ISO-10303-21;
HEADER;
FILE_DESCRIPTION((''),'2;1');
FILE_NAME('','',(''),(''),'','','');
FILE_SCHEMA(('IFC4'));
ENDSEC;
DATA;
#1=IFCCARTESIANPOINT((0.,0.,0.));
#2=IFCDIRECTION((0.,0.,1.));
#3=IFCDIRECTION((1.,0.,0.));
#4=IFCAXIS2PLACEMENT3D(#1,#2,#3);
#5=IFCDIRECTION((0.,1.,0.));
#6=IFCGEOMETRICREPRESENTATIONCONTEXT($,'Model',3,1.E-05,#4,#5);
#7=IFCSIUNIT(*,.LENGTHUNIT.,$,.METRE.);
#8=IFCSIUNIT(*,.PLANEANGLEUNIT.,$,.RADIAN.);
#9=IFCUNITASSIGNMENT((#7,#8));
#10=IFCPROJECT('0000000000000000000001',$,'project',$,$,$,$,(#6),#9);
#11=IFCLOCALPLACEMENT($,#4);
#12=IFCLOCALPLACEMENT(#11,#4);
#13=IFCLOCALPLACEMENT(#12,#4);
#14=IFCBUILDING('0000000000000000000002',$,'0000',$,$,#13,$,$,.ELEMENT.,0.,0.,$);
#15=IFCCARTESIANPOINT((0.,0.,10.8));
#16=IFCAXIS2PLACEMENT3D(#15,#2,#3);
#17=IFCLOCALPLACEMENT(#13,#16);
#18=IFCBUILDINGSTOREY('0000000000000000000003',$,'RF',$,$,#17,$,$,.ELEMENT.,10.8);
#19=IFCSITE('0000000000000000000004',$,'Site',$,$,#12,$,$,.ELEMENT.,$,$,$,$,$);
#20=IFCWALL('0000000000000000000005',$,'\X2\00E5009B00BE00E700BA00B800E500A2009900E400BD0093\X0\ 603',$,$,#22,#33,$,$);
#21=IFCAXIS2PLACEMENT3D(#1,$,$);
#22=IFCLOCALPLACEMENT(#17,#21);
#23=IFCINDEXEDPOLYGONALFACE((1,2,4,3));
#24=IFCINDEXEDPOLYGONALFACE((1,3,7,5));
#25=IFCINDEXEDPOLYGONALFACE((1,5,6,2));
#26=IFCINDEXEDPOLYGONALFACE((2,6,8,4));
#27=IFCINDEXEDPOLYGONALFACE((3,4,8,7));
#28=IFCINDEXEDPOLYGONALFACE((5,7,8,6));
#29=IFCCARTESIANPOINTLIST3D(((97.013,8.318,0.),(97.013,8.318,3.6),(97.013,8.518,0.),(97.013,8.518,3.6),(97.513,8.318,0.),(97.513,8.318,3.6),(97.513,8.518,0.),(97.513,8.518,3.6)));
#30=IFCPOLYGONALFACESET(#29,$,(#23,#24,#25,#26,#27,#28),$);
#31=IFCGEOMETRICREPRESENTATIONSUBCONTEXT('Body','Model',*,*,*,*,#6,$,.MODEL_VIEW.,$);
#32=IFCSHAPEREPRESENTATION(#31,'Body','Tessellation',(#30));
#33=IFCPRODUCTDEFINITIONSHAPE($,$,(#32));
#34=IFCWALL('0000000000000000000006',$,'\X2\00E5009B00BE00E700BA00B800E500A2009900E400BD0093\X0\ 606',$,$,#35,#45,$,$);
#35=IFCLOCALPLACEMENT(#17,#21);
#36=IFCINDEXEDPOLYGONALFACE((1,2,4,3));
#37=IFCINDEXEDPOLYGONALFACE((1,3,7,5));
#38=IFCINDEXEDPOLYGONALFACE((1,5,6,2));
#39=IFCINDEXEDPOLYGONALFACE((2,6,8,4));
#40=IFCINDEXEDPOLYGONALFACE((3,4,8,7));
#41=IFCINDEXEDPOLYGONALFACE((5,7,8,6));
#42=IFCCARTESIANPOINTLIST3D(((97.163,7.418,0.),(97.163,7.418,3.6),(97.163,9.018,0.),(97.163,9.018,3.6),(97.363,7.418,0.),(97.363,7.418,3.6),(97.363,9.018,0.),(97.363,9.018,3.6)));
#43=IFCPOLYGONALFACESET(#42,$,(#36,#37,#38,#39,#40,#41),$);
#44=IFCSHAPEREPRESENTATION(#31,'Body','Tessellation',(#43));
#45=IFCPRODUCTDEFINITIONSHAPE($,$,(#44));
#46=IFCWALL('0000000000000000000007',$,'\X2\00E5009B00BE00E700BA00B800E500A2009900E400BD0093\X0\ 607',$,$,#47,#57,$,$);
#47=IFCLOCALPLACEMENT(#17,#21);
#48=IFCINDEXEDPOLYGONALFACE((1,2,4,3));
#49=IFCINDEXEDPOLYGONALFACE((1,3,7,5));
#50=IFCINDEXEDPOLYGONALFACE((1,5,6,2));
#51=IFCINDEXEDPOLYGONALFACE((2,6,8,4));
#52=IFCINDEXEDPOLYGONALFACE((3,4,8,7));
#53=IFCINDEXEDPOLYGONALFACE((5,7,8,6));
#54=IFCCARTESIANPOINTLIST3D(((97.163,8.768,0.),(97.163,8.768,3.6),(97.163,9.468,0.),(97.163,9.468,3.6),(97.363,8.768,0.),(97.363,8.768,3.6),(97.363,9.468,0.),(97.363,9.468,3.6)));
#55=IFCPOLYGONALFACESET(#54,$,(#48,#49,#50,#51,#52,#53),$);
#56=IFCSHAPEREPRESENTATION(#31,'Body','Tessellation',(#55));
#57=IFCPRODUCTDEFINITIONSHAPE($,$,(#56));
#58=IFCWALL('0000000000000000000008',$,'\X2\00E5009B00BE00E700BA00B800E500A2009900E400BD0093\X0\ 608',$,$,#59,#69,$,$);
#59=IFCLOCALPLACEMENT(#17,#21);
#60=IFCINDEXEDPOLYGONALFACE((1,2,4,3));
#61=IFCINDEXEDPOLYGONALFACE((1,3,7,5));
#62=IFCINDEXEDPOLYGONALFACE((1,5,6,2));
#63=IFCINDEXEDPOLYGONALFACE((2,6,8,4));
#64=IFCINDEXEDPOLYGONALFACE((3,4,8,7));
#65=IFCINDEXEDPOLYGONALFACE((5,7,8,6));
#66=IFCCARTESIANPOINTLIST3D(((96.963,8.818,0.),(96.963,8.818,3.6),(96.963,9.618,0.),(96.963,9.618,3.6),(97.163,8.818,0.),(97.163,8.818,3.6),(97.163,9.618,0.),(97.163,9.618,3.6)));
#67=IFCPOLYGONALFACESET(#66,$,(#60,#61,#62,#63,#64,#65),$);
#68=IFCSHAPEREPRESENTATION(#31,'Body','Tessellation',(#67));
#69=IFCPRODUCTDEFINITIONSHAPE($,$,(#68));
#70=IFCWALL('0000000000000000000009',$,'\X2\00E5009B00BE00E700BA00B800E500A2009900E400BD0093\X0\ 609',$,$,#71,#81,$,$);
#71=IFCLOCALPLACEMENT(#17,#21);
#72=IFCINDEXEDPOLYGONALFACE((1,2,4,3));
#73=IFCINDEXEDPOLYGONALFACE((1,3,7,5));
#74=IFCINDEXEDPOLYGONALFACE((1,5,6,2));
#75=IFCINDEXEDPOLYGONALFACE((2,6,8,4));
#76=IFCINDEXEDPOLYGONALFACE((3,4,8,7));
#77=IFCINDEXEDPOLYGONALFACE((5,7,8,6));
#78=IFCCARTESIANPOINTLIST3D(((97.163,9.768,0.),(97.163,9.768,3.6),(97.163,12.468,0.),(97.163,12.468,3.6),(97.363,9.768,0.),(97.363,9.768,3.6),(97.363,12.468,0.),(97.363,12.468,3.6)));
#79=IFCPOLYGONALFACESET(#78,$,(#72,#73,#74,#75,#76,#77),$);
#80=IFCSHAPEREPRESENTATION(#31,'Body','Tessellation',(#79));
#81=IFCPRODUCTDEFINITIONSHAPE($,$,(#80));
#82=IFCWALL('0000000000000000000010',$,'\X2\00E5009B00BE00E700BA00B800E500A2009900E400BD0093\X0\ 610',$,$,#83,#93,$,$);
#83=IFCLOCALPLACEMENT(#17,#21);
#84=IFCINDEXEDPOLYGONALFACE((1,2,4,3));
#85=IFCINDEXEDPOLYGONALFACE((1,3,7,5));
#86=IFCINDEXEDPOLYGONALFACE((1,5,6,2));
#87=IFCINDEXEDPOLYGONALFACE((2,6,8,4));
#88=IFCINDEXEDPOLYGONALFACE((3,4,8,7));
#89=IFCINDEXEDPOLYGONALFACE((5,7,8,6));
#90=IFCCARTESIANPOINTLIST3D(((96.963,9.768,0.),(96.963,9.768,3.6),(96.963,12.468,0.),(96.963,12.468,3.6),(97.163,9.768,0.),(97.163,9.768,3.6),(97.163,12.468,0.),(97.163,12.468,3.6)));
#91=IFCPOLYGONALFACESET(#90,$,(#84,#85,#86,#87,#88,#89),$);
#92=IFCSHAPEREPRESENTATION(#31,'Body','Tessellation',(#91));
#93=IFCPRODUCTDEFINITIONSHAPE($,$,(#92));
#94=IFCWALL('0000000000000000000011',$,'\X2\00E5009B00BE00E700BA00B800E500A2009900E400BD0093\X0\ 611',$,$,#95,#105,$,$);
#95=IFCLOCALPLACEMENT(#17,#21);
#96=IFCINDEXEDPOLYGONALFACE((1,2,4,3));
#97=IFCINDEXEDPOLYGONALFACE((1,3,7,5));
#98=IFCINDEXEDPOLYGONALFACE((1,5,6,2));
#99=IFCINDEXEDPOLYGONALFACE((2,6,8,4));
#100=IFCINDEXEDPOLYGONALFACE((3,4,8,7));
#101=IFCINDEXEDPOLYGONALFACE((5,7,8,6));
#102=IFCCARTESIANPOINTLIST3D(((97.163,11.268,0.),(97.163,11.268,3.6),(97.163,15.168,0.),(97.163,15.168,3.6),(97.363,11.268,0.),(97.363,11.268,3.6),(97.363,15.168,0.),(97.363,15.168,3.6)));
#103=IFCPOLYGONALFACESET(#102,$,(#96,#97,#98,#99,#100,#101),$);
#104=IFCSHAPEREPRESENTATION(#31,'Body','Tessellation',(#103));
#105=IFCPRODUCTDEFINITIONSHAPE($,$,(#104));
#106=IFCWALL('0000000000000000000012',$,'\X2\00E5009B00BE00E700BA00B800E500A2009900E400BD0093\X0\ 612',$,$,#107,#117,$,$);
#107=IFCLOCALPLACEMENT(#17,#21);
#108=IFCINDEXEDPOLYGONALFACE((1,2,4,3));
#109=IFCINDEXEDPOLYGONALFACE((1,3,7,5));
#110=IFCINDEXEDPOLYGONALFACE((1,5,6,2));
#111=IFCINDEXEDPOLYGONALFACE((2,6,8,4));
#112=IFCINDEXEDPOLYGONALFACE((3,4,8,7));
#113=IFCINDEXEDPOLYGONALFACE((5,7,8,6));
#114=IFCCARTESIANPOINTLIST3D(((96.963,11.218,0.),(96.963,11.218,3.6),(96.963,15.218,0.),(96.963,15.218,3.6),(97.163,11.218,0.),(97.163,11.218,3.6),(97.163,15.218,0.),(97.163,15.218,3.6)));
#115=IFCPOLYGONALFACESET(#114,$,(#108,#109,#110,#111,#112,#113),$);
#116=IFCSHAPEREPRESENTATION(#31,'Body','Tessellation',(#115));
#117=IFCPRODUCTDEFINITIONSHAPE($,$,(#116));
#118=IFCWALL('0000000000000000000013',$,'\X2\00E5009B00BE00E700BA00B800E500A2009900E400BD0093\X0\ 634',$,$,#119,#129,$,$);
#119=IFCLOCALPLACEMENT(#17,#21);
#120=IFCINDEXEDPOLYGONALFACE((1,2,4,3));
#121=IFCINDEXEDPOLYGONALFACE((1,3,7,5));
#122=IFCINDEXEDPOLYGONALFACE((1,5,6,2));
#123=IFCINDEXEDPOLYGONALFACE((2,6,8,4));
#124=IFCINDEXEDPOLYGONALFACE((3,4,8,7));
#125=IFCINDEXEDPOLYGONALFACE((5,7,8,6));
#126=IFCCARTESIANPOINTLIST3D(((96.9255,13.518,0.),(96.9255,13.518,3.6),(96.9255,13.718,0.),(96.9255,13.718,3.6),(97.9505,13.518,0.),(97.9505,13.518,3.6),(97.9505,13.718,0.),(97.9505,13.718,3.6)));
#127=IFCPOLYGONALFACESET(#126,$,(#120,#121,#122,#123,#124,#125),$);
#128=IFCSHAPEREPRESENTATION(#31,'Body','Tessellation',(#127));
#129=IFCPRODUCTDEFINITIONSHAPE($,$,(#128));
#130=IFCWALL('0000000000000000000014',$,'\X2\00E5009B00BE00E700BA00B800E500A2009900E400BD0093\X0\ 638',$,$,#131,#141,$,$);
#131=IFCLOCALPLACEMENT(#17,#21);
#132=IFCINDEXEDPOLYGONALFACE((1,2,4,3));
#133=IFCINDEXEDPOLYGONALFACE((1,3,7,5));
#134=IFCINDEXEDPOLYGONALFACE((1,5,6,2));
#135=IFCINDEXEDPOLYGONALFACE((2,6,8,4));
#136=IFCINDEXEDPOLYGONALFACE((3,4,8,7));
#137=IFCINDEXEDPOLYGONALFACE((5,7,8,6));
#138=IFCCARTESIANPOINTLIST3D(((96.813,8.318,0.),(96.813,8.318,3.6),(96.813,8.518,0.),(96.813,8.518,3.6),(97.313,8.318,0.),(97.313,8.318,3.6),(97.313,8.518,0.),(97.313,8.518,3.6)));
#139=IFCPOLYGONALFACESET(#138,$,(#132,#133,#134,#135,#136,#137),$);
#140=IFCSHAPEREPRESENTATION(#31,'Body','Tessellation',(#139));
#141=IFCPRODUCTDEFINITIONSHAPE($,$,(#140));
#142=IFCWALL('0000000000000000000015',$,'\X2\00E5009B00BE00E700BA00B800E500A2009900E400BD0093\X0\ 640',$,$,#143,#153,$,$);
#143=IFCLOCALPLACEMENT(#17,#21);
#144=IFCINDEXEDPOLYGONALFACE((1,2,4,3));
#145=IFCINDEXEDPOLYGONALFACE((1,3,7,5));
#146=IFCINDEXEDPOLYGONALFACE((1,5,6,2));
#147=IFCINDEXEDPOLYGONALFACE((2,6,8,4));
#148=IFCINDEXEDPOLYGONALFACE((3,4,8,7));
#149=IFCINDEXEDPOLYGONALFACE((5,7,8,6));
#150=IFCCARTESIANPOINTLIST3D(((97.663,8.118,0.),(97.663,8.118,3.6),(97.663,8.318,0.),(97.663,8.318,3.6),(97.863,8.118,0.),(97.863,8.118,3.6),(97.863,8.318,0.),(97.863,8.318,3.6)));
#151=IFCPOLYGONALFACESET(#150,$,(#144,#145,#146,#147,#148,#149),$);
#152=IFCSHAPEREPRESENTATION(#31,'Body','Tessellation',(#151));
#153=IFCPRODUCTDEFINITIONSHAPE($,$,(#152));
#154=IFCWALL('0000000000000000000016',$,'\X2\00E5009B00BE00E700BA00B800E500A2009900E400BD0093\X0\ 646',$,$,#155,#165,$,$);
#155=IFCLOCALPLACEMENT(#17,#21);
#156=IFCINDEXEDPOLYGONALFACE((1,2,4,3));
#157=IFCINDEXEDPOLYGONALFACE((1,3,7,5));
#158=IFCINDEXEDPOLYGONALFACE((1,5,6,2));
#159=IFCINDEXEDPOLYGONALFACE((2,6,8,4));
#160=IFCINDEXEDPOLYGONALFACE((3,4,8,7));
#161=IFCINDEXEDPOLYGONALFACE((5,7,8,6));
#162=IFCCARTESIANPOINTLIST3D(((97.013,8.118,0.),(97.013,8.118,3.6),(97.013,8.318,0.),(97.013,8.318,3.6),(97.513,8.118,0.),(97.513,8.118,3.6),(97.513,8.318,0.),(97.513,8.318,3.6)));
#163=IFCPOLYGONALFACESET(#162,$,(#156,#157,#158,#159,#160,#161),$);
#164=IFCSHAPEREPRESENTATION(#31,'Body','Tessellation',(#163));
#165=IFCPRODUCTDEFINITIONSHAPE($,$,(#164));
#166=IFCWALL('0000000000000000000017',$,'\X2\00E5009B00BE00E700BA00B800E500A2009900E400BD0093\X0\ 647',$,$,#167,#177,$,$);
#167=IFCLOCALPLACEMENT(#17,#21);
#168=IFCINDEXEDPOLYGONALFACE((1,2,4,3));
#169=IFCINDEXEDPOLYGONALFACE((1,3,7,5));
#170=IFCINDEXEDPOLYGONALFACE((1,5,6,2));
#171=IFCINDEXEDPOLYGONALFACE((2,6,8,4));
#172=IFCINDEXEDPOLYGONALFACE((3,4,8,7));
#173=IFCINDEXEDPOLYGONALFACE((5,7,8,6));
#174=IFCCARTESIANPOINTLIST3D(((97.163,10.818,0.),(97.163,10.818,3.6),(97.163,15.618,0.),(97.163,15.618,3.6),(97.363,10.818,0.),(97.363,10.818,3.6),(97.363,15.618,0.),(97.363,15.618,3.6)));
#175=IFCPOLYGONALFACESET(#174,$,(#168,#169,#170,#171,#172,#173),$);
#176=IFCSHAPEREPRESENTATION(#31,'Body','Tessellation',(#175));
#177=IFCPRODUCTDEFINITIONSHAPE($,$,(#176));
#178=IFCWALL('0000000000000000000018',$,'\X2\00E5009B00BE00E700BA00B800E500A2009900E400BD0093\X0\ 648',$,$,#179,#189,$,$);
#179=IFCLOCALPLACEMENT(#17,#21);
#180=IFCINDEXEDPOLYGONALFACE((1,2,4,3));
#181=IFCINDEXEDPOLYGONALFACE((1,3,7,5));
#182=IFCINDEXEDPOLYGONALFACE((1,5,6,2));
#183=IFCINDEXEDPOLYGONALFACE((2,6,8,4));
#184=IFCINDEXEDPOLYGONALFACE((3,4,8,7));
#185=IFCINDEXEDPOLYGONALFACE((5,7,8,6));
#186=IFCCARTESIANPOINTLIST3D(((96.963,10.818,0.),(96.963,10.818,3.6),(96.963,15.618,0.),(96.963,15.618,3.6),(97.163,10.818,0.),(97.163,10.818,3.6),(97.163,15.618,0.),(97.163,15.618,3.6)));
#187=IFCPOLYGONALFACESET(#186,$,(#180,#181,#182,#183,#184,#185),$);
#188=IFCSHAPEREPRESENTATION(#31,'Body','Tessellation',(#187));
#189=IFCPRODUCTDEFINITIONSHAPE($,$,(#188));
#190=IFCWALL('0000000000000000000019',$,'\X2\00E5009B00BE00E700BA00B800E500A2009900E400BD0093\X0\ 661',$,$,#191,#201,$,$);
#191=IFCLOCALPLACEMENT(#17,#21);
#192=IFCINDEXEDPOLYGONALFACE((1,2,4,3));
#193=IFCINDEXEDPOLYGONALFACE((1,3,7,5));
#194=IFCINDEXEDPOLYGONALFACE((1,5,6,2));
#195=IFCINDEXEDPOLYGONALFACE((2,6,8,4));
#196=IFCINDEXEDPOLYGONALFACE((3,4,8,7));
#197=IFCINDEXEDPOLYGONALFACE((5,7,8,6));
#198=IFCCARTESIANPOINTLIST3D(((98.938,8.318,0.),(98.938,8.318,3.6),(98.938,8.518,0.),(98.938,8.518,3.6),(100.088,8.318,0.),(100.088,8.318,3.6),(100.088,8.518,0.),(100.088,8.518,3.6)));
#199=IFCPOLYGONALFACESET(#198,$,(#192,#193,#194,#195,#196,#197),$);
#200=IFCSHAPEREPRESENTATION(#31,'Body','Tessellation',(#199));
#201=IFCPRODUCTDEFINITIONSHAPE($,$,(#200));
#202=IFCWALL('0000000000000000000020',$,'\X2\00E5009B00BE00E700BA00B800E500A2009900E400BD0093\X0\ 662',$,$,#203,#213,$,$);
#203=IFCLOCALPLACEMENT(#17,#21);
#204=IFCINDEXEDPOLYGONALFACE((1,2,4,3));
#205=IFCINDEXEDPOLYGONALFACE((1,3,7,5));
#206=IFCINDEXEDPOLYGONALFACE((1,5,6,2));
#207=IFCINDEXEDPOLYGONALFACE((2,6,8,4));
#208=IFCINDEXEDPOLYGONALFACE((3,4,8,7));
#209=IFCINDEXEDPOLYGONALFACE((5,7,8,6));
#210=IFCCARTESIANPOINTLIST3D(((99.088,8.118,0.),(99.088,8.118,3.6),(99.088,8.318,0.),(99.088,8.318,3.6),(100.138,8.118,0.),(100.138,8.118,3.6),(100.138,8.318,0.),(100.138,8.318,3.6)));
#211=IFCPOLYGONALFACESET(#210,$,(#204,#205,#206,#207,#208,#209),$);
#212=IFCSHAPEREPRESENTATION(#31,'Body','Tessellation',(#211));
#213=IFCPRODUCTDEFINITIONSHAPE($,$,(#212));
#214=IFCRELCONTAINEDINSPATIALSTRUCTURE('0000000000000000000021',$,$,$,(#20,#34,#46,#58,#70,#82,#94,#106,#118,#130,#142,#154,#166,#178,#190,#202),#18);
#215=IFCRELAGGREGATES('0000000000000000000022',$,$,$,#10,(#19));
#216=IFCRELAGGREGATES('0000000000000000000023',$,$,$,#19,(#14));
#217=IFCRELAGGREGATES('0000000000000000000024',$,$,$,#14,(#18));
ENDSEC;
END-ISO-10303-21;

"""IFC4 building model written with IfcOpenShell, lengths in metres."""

from ifc_helpers import new_model, si_unit, direction, frame, frame_2d, origin_with_axes, place, context, subcontext, project, spatial, rectangle, extrude, element, save


model = new_model("IFC4")

# Units and contexts
model_context = context("Model", 3, precision=1e-05, world=origin_with_axes(), true_north=direction((0.0, 1.0, 0.0)))
body_context = subcontext(model_context, "Body", "Model", "MODEL_VIEW")
ifc_project = project(units=[si_unit("LENGTHUNIT", "METRE"), si_unit("PLANEANGLEUNIT", "RADIAN")], contexts=[model_context])

# Site, building, storey
placement = place(None, origin_with_axes())
site_placement = place(placement, origin_with_axes())
site = spatial("IfcSite", under=ifc_project, at=site_placement, Name="Site", CompositionType="ELEMENT")
building_placement = place(site_placement, origin_with_axes())
building = spatial("IfcBuilding", under=site, at=building_placement, Name="0000", CompositionType="ELEMENT", ElevationOfRefHeight=0.0, ElevationOfTerrain=0.0)
storey_placement = place(building_placement, frame((0.0, 0.0, 10.8), z_axis=(0.0, 0.0, 1.0), x_axis=(1.0, 0.0, 0.0)))
storey = spatial("IfcBuildingStorey", under=building, at=storey_placement, Name="RF", CompositionType="ELEMENT", Elevation=10.8)

# Walls
wall_1_placement = place(storey_placement, frame((97.263, 8.418, 0.0), z_axis=(0.0, 0.0, 1.0), x_axis=(1.0, 0.0, 0.0)))
element("IfcWall", 1, at=wall_1_placement, inside=storey, Name="å\u009b¾çº¸å¢\u0099ä½\u0093 603", context=body_context, shape_type="SweptSolid", body=[
    extrude(rectangle(XDim=0.5, YDim=0.2, at=frame_2d((0.0, 0.0), x_axis=(1.0, 0.0, 0.0))), frame((0.0, 0.0, 0.0), z_axis=(0.0, 0.0, 1.0)), (0.0, 0.0, 1.0), 3.6),
])
wall_2_placement = place(storey_placement, frame((97.263, 8.218, 0.0), z_axis=(0.0, 0.0, 1.0), x_axis=(0.0, -1.0, 0.0)))
element("IfcWall", 2, at=wall_2_placement, inside=storey, Name="å\u009b¾çº¸å¢\u0099ä½\u0093 606", context=body_context, shape_type="SweptSolid", body=[
    extrude(rectangle(XDim=1.6, YDim=0.2, at=frame_2d((0.0, 0.0), x_axis=(1.0, 0.0, 0.0))), frame((0.0, 0.0, 0.0), z_axis=(0.0, 0.0, 1.0)), (0.0, 0.0, 1.0), 3.6),
])
wall_3_placement = place(storey_placement, frame((97.263, 9.118, 0.0), z_axis=(0.0, 0.0, 1.0), x_axis=(0.0, -1.0, 0.0)))
element("IfcWall", 3, at=wall_3_placement, inside=storey, Name="å\u009b¾çº¸å¢\u0099ä½\u0093 607", context=body_context, shape_type="SweptSolid", body=[
    extrude(rectangle(XDim=0.7, YDim=0.2, at=frame_2d((0.0, 0.0), x_axis=(1.0, 0.0, 0.0))), frame((0.0, 0.0, 0.0), z_axis=(0.0, 0.0, 1.0)), (0.0, 0.0, 1.0), 3.6),
])
wall_4_placement = place(storey_placement, frame((97.063, 9.218, 0.0), z_axis=(0.0, 0.0, 1.0), x_axis=(0.0, -1.0, 0.0)))
element("IfcWall", 4, at=wall_4_placement, inside=storey, Name="å\u009b¾çº¸å¢\u0099ä½\u0093 608", context=body_context, shape_type="SweptSolid", body=[
    extrude(rectangle(XDim=0.8, YDim=0.2, at=frame_2d((0.0, 0.0), x_axis=(1.0, 0.0, 0.0))), frame((0.0, 0.0, 0.0), z_axis=(0.0, 0.0, 1.0)), (0.0, 0.0, 1.0), 3.6),
])
for number, where, z_axis, x_axis, name in (
    (5, (97.263, 11.118, 0.0), (0.0, 0.0, 1.0), (0.0, -1.0, 0.0), "å\u009b¾çº¸å¢\u0099ä½\u0093 609"),
    (6, (97.063, 11.118, 0.0), (0.0, 0.0, 1.0), (0.0, -1.0, 0.0), "å\u009b¾çº¸å¢\u0099ä½\u0093 610"),
):
    element("IfcWall", number, at=place(storey_placement, frame(where, z_axis=z_axis, x_axis=x_axis)), inside=storey, Name=name, context=body_context, shape_type="SweptSolid", body=[
        extrude(rectangle(XDim=2.7, YDim=0.2, at=frame_2d((0.0, 0.0), x_axis=(1.0, 0.0, 0.0))), frame((0.0, 0.0, 0.0), z_axis=(0.0, 0.0, 1.0)), (0.0, 0.0, 1.0), 3.6),
    ])
wall_5_placement = place(storey_placement, frame((97.263, 13.218, 0.0), z_axis=(0.0, 0.0, 1.0), x_axis=(0.0, -1.0, 0.0)))
element("IfcWall", 7, at=wall_5_placement, inside=storey, Name="å\u009b¾çº¸å¢\u0099ä½\u0093 611", context=body_context, shape_type="SweptSolid", body=[
    extrude(rectangle(XDim=3.9, YDim=0.2, at=frame_2d((0.0, 0.0), x_axis=(1.0, 0.0, 0.0))), frame((0.0, 0.0, 0.0), z_axis=(0.0, 0.0, 1.0)), (0.0, 0.0, 1.0), 3.6),
])
wall_6_placement = place(storey_placement, frame((97.063, 13.218, 0.0), z_axis=(0.0, 0.0, 1.0), x_axis=(0.0, -1.0, 0.0)))
element("IfcWall", 8, at=wall_6_placement, inside=storey, Name="å\u009b¾çº¸å¢\u0099ä½\u0093 612", context=body_context, shape_type="SweptSolid", body=[
    extrude(rectangle(XDim=4.0, YDim=0.2, at=frame_2d((0.0, 0.0), x_axis=(1.0, 0.0, 0.0))), frame((0.0, 0.0, 0.0), z_axis=(0.0, 0.0, 1.0)), (0.0, 0.0, 1.0), 3.6),
])
wall_7_placement = place(storey_placement, frame((97.438, 13.618, 0.0), z_axis=(0.0, 0.0, 1.0), x_axis=(1.0, 0.0, 0.0)))
element("IfcWall", 9, at=wall_7_placement, inside=storey, Name="å\u009b¾çº¸å¢\u0099ä½\u0093 634", context=body_context, shape_type="SweptSolid", body=[
    extrude(rectangle(XDim=1.025, YDim=0.2, at=frame_2d((0.0, 0.0), x_axis=(1.0, 0.0, 0.0))), frame((0.0, 0.0, 0.0), z_axis=(0.0, 0.0, 1.0)), (0.0, 0.0, 1.0), 3.6),
])
wall_8_placement = place(storey_placement, frame((97.063, 8.418, 0.0), z_axis=(0.0, 0.0, 1.0), x_axis=(-1.0, 0.0, 0.0)))
element("IfcWall", 10, at=wall_8_placement, inside=storey, Name="å\u009b¾çº¸å¢\u0099ä½\u0093 638", context=body_context, shape_type="SweptSolid", body=[
    extrude(rectangle(XDim=0.5, YDim=0.2, at=frame_2d((0.0, 0.0), x_axis=(1.0, 0.0, 0.0))), frame((0.0, 0.0, 0.0), z_axis=(0.0, 0.0, 1.0)), (0.0, 0.0, 1.0), 3.6),
])
wall_9_placement = place(storey_placement, frame((97.763, 8.218, 0.0), z_axis=(0.0, 0.0, 1.0), x_axis=(0.0, 1.0, 0.0)))
element("IfcWall", 11, at=wall_9_placement, inside=storey, Name="å\u009b¾çº¸å¢\u0099ä½\u0093 640", context=body_context, shape_type="SweptSolid", body=[
    extrude(rectangle(XDim=0.2, YDim=0.2, at=frame_2d((0.0, 0.0), x_axis=(1.0, 0.0, 0.0))), frame((0.0, 0.0, 0.0), z_axis=(0.0, 0.0, 1.0)), (0.0, 0.0, 1.0), 3.6),
])
for number, where, z_axis, x_axis, name in (
    (12, (97.263, 8.218, 0.0), (0.0, 0.0, 1.0), (1.0, 0.0, 0.0), "å\u009b¾çº¸å¢\u0099ä½\u0093 646"),
):
    element("IfcWall", number, at=place(storey_placement, frame(where, z_axis=z_axis, x_axis=x_axis)), inside=storey, Name=name, context=body_context, shape_type="SweptSolid", body=[
        extrude(rectangle(XDim=0.5, YDim=0.2, at=frame_2d((0.0, 0.0), x_axis=(1.0, 0.0, 0.0))), frame((0.0, 0.0, 0.0), z_axis=(0.0, 0.0, 1.0)), (0.0, 0.0, 1.0), 3.6),
    ])
for number, where, z_axis, x_axis, name in (
    (13, (97.263, 13.218, 0.0), (0.0, 0.0, 1.0), (0.0, -1.0, 0.0), "å\u009b¾çº¸å¢\u0099ä½\u0093 647"),
    (14, (97.063, 13.218, 0.0), (0.0, 0.0, 1.0), (0.0, -1.0, 0.0), "å\u009b¾çº¸å¢\u0099ä½\u0093 648"),
):
    element("IfcWall", number, at=place(storey_placement, frame(where, z_axis=z_axis, x_axis=x_axis)), inside=storey, Name=name, context=body_context, shape_type="SweptSolid", body=[
        extrude(rectangle(XDim=4.8, YDim=0.2, at=frame_2d((0.0, 0.0), x_axis=(1.0, 0.0, 0.0))), frame((0.0, 0.0, 0.0), z_axis=(0.0, 0.0, 1.0)), (0.0, 0.0, 1.0), 3.6),
    ])
wall_10_placement = place(storey_placement, frame((99.513, 8.418, 0.0), z_axis=(0.0, 0.0, 1.0), x_axis=(1.0, 0.0, 0.0)))
element("IfcWall", 15, at=wall_10_placement, inside=storey, Name="å\u009b¾çº¸å¢\u0099ä½\u0093 661", context=body_context, shape_type="SweptSolid", body=[
    extrude(rectangle(XDim=1.15, YDim=0.2, at=frame_2d((0.0, 0.0), x_axis=(1.0, 0.0, 0.0))), frame((0.0, 0.0, 0.0), z_axis=(0.0, 0.0, 1.0)), (0.0, 0.0, 1.0), 3.6),
])
wall_11_placement = place(storey_placement, frame((99.613, 8.218, 0.0), z_axis=(0.0, 0.0, 1.0), x_axis=(1.0, 0.0, 0.0)))
element("IfcWall", 16, at=wall_11_placement, inside=storey, Name="å\u009b¾çº¸å¢\u0099ä½\u0093 662", context=body_context, shape_type="SweptSolid", body=[
    extrude(rectangle(XDim=1.05, YDim=0.2, at=frame_2d((0.0, 0.0), x_axis=(1.0, 0.0, 0.0))), frame((0.0, 0.0, 0.0), z_axis=(0.0, 0.0, 1.0)), (0.0, 0.0, 1.0), 3.6),
])

save(model, "model.ifc")
